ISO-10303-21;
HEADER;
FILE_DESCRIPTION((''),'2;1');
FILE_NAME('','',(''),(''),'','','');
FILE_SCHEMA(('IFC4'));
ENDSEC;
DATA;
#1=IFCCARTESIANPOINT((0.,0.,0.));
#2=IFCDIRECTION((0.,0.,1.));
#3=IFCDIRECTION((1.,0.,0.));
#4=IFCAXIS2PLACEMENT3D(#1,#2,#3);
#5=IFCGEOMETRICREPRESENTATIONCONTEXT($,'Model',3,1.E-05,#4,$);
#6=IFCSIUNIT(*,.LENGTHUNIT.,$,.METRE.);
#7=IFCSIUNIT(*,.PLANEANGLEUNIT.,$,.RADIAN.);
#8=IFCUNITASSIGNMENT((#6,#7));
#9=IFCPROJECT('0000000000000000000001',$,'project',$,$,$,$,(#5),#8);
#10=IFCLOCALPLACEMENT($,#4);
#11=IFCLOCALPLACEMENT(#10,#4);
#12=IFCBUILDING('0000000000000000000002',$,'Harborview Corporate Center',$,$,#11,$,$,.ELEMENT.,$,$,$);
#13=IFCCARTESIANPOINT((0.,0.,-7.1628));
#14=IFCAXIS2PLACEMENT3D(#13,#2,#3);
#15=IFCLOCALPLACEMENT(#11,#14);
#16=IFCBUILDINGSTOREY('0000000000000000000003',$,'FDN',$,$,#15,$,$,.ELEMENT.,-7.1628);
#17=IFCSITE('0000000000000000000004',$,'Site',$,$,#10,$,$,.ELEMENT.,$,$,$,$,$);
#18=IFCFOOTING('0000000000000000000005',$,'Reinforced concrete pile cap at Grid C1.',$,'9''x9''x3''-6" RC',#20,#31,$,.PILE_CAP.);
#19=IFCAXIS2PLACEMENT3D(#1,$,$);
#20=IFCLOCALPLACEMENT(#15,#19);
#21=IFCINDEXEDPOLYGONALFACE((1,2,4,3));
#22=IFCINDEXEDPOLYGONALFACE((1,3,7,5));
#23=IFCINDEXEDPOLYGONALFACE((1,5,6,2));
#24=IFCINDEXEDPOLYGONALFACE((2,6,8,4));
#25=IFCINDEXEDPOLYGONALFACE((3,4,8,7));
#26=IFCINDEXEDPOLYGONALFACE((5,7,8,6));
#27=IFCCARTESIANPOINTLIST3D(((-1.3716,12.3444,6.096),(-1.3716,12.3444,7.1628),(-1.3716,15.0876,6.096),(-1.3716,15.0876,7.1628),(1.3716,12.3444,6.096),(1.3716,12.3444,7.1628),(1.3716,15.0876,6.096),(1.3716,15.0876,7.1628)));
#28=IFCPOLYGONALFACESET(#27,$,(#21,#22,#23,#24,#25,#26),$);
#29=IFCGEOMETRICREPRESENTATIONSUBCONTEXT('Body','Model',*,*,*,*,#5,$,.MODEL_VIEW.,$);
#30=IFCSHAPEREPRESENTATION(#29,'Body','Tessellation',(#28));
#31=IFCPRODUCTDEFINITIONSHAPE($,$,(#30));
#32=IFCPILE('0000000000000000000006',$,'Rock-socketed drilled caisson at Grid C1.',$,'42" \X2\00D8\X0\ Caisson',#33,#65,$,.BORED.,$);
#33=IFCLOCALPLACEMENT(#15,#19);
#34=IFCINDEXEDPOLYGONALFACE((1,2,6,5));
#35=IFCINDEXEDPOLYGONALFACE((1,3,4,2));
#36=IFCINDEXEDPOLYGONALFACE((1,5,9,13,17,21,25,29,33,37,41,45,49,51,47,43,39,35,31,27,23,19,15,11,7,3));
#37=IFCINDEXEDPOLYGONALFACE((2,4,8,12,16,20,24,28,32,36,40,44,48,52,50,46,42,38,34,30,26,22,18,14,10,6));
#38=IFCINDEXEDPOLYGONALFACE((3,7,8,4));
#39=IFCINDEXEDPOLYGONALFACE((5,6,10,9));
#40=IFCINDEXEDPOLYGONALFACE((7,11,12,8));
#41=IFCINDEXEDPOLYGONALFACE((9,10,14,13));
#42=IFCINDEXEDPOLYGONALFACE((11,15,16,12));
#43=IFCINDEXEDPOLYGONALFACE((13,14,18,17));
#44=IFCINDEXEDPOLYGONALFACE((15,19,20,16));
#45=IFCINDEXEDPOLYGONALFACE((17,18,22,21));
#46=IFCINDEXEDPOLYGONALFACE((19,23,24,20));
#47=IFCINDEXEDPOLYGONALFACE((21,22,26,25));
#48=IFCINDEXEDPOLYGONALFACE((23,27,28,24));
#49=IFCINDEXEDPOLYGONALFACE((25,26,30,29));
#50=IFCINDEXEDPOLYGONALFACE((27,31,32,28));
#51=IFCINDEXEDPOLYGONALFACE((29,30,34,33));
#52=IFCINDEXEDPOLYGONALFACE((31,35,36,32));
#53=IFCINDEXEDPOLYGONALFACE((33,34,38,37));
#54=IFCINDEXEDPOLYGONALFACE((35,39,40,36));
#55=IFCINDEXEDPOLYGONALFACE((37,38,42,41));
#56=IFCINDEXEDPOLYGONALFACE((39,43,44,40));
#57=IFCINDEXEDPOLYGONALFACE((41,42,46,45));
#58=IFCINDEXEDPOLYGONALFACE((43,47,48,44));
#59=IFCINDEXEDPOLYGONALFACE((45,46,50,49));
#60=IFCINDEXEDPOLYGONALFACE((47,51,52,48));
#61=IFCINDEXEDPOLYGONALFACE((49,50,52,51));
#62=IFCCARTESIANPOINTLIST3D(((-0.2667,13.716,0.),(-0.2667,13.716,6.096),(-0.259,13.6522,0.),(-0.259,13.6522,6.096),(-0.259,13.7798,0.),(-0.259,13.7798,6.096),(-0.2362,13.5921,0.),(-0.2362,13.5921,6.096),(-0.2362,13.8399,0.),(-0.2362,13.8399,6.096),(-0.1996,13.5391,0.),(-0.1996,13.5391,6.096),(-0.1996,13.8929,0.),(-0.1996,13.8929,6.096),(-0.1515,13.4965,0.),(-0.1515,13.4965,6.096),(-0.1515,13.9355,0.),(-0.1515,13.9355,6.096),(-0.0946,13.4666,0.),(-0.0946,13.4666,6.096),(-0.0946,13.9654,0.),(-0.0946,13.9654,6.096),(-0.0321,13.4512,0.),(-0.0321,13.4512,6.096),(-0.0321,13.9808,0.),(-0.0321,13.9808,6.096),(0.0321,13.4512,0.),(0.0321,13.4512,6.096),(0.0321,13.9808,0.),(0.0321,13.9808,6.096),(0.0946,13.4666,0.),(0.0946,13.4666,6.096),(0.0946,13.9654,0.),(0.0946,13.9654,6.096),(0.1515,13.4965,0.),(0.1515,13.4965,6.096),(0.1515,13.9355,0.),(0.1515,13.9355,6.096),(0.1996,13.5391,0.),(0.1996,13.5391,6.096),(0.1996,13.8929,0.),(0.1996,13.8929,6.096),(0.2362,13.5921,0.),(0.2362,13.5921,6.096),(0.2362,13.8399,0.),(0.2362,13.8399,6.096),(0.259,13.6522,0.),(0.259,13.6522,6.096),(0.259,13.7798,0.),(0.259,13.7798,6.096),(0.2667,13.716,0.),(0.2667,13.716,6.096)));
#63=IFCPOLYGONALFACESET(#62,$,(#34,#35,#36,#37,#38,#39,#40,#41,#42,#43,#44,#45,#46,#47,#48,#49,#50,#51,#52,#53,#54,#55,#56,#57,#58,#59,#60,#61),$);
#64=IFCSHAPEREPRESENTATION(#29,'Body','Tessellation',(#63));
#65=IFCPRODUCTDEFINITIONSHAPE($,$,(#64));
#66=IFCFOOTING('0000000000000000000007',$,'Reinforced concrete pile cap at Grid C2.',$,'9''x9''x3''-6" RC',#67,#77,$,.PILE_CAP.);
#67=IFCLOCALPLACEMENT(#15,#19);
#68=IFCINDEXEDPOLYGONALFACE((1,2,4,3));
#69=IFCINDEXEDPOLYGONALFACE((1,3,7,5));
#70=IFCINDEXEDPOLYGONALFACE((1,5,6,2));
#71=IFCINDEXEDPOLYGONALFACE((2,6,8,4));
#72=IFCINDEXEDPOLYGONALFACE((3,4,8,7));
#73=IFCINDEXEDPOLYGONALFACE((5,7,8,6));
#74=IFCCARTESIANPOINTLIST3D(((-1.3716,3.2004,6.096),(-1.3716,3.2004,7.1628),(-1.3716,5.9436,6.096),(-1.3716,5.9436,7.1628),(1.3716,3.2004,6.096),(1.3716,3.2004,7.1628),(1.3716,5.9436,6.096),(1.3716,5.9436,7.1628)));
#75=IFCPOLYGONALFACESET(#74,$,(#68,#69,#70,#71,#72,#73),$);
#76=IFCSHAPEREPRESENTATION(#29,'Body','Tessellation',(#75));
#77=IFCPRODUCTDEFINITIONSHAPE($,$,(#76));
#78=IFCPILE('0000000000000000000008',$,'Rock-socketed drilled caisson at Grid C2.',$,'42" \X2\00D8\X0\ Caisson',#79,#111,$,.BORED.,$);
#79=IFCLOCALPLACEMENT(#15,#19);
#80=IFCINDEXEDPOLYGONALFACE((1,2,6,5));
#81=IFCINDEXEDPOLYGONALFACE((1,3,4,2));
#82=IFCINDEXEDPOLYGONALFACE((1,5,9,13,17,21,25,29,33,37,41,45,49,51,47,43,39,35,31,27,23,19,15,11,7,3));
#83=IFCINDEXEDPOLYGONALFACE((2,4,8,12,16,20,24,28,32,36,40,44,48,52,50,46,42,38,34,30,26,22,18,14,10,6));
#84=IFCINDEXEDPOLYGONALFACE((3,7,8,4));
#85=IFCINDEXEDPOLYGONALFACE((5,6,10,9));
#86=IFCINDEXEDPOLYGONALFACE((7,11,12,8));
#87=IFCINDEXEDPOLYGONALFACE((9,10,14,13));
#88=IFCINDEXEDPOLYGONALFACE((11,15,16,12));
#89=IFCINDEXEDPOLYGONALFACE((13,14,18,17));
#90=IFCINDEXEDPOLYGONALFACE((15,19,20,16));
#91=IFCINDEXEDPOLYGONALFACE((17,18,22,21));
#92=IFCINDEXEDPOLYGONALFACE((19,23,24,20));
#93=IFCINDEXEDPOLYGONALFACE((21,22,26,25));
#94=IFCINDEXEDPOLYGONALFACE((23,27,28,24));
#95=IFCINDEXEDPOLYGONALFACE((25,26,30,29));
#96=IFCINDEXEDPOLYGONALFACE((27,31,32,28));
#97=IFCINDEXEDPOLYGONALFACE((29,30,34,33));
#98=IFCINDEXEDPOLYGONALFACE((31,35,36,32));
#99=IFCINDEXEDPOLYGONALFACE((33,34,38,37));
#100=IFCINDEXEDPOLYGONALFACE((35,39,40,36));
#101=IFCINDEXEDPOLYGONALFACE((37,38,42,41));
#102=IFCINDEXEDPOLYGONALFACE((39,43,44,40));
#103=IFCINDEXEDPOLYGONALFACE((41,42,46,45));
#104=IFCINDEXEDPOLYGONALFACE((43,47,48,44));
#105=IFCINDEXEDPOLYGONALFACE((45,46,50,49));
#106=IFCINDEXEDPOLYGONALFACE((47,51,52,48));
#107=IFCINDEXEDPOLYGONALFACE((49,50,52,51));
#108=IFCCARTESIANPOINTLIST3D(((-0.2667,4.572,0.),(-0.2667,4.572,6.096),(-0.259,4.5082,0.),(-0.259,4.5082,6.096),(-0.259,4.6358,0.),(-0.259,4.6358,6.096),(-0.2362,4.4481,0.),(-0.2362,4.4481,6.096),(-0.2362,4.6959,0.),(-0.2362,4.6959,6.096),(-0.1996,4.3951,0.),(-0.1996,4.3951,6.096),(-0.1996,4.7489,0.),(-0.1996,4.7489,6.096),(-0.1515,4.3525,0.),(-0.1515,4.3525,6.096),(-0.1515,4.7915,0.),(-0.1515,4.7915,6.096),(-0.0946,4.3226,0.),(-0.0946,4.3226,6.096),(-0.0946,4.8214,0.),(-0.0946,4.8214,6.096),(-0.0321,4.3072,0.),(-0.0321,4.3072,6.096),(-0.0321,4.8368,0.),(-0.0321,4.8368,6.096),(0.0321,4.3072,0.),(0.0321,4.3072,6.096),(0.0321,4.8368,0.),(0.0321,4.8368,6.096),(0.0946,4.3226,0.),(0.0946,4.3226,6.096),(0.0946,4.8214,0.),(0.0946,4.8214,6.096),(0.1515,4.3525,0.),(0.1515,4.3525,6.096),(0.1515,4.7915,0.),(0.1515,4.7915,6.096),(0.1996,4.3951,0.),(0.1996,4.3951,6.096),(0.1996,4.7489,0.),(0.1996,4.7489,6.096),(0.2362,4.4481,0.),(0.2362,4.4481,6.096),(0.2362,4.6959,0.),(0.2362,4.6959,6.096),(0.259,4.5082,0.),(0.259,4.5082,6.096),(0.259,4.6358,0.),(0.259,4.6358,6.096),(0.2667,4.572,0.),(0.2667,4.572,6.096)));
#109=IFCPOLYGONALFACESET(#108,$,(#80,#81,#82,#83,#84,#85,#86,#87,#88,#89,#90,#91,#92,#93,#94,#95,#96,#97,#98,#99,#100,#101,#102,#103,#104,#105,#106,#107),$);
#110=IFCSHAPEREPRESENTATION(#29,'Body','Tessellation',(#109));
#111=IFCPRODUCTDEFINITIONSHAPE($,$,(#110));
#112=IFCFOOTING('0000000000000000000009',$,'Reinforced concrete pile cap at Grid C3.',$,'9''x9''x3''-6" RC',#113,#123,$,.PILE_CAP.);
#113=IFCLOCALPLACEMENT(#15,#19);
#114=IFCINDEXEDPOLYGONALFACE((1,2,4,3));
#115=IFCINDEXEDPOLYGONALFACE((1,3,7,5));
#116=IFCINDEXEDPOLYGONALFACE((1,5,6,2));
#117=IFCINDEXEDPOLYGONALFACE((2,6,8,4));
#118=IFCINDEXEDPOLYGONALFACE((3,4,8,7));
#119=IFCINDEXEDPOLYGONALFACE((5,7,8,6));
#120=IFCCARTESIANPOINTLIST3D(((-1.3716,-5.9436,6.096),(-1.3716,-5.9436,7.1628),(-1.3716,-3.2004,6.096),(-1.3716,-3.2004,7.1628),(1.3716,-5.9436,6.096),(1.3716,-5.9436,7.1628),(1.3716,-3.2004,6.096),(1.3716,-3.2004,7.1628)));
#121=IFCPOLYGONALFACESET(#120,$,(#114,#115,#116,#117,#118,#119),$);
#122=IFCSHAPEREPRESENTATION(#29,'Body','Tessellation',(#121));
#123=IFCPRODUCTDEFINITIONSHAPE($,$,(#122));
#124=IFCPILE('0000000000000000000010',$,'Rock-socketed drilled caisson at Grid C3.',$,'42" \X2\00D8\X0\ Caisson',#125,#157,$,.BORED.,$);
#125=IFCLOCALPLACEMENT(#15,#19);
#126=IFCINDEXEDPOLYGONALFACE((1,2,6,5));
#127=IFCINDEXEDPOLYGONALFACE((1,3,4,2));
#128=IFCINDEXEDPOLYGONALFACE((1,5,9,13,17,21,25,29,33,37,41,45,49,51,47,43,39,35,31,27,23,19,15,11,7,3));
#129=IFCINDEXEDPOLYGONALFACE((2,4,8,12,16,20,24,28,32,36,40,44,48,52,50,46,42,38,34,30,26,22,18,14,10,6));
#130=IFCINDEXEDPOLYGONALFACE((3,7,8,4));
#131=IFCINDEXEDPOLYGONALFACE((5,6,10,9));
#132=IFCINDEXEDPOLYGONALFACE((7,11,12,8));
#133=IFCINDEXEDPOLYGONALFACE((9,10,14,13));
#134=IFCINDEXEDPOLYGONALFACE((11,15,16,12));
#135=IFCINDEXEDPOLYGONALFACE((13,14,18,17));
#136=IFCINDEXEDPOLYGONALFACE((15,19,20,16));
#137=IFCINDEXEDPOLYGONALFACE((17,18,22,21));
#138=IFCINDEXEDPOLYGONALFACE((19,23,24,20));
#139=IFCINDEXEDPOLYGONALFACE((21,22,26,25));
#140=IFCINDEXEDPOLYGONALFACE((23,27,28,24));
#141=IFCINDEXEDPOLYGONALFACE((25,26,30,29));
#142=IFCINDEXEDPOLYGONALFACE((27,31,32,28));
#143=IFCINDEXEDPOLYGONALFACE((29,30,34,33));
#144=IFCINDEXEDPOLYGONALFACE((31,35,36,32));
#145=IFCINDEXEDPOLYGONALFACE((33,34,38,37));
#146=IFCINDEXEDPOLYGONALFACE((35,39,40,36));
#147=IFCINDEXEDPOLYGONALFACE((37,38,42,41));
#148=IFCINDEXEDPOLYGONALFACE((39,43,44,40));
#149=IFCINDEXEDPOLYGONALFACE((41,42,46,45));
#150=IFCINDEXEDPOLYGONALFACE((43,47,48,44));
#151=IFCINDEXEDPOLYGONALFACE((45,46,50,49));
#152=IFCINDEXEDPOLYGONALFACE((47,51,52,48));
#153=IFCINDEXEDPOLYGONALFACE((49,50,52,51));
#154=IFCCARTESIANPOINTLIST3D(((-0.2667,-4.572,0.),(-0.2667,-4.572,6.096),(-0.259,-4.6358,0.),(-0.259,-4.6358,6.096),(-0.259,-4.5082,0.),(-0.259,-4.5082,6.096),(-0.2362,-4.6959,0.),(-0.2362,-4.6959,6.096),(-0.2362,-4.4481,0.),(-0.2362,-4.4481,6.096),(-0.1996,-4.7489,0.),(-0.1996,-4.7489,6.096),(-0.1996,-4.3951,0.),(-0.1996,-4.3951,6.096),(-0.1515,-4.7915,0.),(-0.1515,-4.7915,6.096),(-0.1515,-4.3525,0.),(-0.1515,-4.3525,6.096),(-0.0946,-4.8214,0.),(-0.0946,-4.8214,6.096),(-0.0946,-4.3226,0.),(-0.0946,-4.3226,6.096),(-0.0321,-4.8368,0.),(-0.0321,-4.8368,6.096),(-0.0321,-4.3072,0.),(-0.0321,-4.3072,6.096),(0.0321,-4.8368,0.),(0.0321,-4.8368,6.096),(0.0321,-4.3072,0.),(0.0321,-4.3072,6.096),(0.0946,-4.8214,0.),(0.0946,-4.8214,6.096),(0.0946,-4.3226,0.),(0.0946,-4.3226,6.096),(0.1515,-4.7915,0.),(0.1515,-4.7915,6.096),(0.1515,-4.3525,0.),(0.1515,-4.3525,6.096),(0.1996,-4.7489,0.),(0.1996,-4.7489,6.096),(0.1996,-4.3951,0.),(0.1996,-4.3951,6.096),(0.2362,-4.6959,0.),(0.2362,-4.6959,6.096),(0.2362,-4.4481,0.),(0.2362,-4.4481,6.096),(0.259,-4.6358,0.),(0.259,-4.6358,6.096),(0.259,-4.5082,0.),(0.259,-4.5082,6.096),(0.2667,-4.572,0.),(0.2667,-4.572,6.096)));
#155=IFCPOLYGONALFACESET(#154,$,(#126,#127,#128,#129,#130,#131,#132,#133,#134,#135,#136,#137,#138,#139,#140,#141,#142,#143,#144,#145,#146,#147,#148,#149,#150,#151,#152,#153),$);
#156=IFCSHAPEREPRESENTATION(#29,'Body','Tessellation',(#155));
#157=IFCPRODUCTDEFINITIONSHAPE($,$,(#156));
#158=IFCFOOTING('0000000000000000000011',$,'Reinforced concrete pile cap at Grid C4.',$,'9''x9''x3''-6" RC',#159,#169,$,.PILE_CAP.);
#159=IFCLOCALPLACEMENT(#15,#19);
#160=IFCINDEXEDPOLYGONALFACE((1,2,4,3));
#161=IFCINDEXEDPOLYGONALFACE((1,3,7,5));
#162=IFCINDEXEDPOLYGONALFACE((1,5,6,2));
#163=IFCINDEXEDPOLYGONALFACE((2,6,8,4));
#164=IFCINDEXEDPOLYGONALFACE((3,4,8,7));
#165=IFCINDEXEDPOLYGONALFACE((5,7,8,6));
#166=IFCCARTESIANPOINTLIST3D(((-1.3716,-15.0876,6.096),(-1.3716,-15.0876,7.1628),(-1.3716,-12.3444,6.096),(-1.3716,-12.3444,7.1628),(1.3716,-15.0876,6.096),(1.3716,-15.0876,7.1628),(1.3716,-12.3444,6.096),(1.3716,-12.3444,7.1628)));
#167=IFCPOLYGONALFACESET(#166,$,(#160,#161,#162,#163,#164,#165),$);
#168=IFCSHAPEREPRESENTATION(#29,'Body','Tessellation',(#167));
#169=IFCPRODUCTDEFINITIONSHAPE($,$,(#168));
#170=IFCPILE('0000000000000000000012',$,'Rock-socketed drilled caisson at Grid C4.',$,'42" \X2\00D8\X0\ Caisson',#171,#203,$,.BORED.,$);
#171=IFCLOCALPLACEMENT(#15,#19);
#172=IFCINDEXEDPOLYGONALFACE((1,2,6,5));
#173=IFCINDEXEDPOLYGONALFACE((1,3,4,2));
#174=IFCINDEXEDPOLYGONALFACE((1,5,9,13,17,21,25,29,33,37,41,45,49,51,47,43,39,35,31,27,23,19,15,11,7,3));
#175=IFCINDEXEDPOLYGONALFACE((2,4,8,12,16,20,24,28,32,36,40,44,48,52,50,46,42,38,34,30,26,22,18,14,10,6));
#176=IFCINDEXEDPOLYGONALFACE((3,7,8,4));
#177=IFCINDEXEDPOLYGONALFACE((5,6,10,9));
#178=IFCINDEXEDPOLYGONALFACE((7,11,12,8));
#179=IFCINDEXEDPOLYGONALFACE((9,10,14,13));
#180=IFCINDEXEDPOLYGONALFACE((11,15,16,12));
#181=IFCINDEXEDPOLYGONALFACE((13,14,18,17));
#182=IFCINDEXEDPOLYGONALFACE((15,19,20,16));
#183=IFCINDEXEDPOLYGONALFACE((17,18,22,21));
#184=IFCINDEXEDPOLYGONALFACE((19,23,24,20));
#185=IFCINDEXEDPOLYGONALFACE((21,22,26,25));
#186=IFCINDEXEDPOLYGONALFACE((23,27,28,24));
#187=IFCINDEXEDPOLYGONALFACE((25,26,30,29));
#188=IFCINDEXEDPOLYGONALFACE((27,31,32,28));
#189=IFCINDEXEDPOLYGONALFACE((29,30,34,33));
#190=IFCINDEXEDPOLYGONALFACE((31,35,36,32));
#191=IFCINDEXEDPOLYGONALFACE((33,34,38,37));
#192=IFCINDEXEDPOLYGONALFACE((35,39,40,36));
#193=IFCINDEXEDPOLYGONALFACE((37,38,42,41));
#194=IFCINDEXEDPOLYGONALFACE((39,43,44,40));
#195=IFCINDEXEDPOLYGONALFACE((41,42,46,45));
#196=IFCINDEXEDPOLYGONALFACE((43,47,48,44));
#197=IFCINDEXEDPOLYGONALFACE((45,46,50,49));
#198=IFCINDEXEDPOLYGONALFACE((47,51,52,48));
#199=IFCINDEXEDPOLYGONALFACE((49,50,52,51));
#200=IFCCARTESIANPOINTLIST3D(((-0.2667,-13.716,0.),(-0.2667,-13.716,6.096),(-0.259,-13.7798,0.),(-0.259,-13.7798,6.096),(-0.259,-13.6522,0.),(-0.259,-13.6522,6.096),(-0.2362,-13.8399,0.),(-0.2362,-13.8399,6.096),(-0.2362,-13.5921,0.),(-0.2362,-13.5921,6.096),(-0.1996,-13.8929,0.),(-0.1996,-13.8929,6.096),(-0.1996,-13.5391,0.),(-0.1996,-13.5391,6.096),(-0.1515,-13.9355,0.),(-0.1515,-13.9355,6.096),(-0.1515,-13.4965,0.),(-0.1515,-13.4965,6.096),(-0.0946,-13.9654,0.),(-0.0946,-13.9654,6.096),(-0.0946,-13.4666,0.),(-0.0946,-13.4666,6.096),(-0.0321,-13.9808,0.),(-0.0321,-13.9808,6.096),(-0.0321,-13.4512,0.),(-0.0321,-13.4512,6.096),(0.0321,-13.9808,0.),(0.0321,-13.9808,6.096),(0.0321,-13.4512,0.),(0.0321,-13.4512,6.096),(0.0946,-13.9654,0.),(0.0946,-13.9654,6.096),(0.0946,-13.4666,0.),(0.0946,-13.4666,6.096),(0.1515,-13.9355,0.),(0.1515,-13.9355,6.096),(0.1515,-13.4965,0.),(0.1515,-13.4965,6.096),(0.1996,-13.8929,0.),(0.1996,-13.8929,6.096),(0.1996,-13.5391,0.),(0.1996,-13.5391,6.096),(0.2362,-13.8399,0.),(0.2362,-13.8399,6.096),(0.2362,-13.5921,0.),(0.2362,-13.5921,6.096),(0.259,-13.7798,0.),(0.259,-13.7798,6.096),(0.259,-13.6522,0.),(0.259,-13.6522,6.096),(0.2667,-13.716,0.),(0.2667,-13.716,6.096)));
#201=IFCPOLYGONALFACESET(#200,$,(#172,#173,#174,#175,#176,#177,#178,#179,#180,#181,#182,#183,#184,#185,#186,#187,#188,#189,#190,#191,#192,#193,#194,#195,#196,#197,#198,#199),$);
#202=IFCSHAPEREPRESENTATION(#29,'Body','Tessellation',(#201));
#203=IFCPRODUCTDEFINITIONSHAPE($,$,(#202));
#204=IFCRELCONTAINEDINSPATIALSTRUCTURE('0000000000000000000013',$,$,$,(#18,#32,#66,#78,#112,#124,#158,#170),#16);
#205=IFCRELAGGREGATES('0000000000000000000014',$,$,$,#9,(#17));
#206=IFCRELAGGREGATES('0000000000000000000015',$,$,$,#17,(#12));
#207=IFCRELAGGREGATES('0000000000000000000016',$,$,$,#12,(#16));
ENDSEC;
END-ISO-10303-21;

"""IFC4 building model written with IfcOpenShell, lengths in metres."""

from ifc_helpers import new_model, si_unit, frame, origin_with_axes, place, context, subcontext, project, spatial, rectangle, circle, extrude, element, save


model = new_model("IFC4")

# Units and contexts
model_context = context("Model", 3, precision=1e-05, world=origin_with_axes())
body_context = subcontext(model_context, "Body", "Model", "MODEL_VIEW")
ifc_project = project(units=[si_unit("LENGTHUNIT", "METRE"), si_unit("PLANEANGLEUNIT", "RADIAN")], contexts=[model_context])

# Site, building, storey
site_placement = place(None, origin_with_axes())
site = spatial("IfcSite", under=ifc_project, at=site_placement, Name="Site", CompositionType="ELEMENT")
building_placement = place(site_placement, origin_with_axes())
building = spatial("IfcBuilding", under=site, at=building_placement, Name="Harborview Corporate Center", CompositionType="ELEMENT")
storey_placement = place(building_placement, frame((0.0, 0.0, -7.1628), z_axis=(0.0, 0.0, 1.0), x_axis=(1.0, 0.0, 0.0)))
storey = spatial("IfcBuildingStorey", under=building, at=storey_placement, Name="FDN", CompositionType="ELEMENT", Elevation=-7.1628)

# Footing
footing_1_placement = place(storey_placement, frame((0.0, 13.716, 6.096), z_axis=(0.0, 0.0, 1.0), x_axis=(1.0, 0.0, 0.0)))
element("IfcFooting", 1, at=footing_1_placement, inside=storey, Name="Reinforced concrete pile cap at Grid C1.", ObjectType="9'x9'x3'-6\" RC", PredefinedType="PILE_CAP", context=body_context, shape_type="SweptSolid", body=[
    extrude(rectangle(XDim=2.7432, YDim=2.7432), origin_with_axes(), (0.0, 0.0, 1.0), 1.0668),
])

# Pile
pile_1_placement = place(storey_placement, frame((0.0, 13.716, 0.0), z_axis=(0.0, 0.0, 1.0), x_axis=(1.0, 0.0, 0.0)))
element("IfcPile", 2, at=pile_1_placement, inside=storey, Name="Rock-socketed drilled caisson at Grid C1.", ObjectType="42\" Ø Caisson", PredefinedType="BORED", context=body_context, shape_type="SweptSolid", body=[
    extrude(circle(Radius=0.2667), origin_with_axes(), (0.0, 0.0, 1.0), 6.096),
])

# Footing
footing_2_placement = place(storey_placement, frame((0.0, 4.572, 6.096), z_axis=(0.0, 0.0, 1.0), x_axis=(1.0, 0.0, 0.0)))
element("IfcFooting", 3, at=footing_2_placement, inside=storey, Name="Reinforced concrete pile cap at Grid C2.", ObjectType="9'x9'x3'-6\" RC", PredefinedType="PILE_CAP", context=body_context, shape_type="SweptSolid", body=[
    extrude(rectangle(XDim=2.7432, YDim=2.7432), origin_with_axes(), (0.0, 0.0, 1.0), 1.0668),
])

# Pile
pile_2_placement = place(storey_placement, frame((0.0, 4.572, 0.0), z_axis=(0.0, 0.0, 1.0), x_axis=(1.0, 0.0, 0.0)))
element("IfcPile", 4, at=pile_2_placement, inside=storey, Name="Rock-socketed drilled caisson at Grid C2.", ObjectType="42\" Ø Caisson", PredefinedType="BORED", context=body_context, shape_type="SweptSolid", body=[
    extrude(circle(Radius=0.2667), origin_with_axes(), (0.0, 0.0, 1.0), 6.096),
])

# Footing
footing_3_placement = place(storey_placement, frame((0.0, -4.572, 6.096), z_axis=(0.0, 0.0, 1.0), x_axis=(1.0, 0.0, 0.0)))
element("IfcFooting", 5, at=footing_3_placement, inside=storey, Name="Reinforced concrete pile cap at Grid C3.", ObjectType="9'x9'x3'-6\" RC", PredefinedType="PILE_CAP", context=body_context, shape_type="SweptSolid", body=[
    extrude(rectangle(XDim=2.7432, YDim=2.7432), origin_with_axes(), (0.0, 0.0, 1.0), 1.0668),
])

# Pile
pile_3_placement = place(storey_placement, frame((0.0, -4.572, 0.0), z_axis=(0.0, 0.0, 1.0), x_axis=(1.0, 0.0, 0.0)))
element("IfcPile", 6, at=pile_3_placement, inside=storey, Name="Rock-socketed drilled caisson at Grid C3.", ObjectType="42\" Ø Caisson", PredefinedType="BORED", context=body_context, shape_type="SweptSolid", body=[
    extrude(circle(Radius=0.2667), origin_with_axes(), (0.0, 0.0, 1.0), 6.096),
])

# Footing
footing_4_placement = place(storey_placement, frame((0.0, -13.716, 6.096), z_axis=(0.0, 0.0, 1.0), x_axis=(1.0, 0.0, 0.0)))
element("IfcFooting", 7, at=footing_4_placement, inside=storey, Name="Reinforced concrete pile cap at Grid C4.", ObjectType="9'x9'x3'-6\" RC", PredefinedType="PILE_CAP", context=body_context, shape_type="SweptSolid", body=[
    extrude(rectangle(XDim=2.7432, YDim=2.7432), origin_with_axes(), (0.0, 0.0, 1.0), 1.0668),
])

# Pile
pile_4_placement = place(storey_placement, frame((0.0, -13.716, 0.0), z_axis=(0.0, 0.0, 1.0), x_axis=(1.0, 0.0, 0.0)))
element("IfcPile", 8, at=pile_4_placement, inside=storey, Name="Rock-socketed drilled caisson at Grid C4.", ObjectType="42\" Ø Caisson", PredefinedType="BORED", context=body_context, shape_type="SweptSolid", body=[
    extrude(circle(Radius=0.2667), origin_with_axes(), (0.0, 0.0, 1.0), 6.096),
])

save(model, "model.ifc")
